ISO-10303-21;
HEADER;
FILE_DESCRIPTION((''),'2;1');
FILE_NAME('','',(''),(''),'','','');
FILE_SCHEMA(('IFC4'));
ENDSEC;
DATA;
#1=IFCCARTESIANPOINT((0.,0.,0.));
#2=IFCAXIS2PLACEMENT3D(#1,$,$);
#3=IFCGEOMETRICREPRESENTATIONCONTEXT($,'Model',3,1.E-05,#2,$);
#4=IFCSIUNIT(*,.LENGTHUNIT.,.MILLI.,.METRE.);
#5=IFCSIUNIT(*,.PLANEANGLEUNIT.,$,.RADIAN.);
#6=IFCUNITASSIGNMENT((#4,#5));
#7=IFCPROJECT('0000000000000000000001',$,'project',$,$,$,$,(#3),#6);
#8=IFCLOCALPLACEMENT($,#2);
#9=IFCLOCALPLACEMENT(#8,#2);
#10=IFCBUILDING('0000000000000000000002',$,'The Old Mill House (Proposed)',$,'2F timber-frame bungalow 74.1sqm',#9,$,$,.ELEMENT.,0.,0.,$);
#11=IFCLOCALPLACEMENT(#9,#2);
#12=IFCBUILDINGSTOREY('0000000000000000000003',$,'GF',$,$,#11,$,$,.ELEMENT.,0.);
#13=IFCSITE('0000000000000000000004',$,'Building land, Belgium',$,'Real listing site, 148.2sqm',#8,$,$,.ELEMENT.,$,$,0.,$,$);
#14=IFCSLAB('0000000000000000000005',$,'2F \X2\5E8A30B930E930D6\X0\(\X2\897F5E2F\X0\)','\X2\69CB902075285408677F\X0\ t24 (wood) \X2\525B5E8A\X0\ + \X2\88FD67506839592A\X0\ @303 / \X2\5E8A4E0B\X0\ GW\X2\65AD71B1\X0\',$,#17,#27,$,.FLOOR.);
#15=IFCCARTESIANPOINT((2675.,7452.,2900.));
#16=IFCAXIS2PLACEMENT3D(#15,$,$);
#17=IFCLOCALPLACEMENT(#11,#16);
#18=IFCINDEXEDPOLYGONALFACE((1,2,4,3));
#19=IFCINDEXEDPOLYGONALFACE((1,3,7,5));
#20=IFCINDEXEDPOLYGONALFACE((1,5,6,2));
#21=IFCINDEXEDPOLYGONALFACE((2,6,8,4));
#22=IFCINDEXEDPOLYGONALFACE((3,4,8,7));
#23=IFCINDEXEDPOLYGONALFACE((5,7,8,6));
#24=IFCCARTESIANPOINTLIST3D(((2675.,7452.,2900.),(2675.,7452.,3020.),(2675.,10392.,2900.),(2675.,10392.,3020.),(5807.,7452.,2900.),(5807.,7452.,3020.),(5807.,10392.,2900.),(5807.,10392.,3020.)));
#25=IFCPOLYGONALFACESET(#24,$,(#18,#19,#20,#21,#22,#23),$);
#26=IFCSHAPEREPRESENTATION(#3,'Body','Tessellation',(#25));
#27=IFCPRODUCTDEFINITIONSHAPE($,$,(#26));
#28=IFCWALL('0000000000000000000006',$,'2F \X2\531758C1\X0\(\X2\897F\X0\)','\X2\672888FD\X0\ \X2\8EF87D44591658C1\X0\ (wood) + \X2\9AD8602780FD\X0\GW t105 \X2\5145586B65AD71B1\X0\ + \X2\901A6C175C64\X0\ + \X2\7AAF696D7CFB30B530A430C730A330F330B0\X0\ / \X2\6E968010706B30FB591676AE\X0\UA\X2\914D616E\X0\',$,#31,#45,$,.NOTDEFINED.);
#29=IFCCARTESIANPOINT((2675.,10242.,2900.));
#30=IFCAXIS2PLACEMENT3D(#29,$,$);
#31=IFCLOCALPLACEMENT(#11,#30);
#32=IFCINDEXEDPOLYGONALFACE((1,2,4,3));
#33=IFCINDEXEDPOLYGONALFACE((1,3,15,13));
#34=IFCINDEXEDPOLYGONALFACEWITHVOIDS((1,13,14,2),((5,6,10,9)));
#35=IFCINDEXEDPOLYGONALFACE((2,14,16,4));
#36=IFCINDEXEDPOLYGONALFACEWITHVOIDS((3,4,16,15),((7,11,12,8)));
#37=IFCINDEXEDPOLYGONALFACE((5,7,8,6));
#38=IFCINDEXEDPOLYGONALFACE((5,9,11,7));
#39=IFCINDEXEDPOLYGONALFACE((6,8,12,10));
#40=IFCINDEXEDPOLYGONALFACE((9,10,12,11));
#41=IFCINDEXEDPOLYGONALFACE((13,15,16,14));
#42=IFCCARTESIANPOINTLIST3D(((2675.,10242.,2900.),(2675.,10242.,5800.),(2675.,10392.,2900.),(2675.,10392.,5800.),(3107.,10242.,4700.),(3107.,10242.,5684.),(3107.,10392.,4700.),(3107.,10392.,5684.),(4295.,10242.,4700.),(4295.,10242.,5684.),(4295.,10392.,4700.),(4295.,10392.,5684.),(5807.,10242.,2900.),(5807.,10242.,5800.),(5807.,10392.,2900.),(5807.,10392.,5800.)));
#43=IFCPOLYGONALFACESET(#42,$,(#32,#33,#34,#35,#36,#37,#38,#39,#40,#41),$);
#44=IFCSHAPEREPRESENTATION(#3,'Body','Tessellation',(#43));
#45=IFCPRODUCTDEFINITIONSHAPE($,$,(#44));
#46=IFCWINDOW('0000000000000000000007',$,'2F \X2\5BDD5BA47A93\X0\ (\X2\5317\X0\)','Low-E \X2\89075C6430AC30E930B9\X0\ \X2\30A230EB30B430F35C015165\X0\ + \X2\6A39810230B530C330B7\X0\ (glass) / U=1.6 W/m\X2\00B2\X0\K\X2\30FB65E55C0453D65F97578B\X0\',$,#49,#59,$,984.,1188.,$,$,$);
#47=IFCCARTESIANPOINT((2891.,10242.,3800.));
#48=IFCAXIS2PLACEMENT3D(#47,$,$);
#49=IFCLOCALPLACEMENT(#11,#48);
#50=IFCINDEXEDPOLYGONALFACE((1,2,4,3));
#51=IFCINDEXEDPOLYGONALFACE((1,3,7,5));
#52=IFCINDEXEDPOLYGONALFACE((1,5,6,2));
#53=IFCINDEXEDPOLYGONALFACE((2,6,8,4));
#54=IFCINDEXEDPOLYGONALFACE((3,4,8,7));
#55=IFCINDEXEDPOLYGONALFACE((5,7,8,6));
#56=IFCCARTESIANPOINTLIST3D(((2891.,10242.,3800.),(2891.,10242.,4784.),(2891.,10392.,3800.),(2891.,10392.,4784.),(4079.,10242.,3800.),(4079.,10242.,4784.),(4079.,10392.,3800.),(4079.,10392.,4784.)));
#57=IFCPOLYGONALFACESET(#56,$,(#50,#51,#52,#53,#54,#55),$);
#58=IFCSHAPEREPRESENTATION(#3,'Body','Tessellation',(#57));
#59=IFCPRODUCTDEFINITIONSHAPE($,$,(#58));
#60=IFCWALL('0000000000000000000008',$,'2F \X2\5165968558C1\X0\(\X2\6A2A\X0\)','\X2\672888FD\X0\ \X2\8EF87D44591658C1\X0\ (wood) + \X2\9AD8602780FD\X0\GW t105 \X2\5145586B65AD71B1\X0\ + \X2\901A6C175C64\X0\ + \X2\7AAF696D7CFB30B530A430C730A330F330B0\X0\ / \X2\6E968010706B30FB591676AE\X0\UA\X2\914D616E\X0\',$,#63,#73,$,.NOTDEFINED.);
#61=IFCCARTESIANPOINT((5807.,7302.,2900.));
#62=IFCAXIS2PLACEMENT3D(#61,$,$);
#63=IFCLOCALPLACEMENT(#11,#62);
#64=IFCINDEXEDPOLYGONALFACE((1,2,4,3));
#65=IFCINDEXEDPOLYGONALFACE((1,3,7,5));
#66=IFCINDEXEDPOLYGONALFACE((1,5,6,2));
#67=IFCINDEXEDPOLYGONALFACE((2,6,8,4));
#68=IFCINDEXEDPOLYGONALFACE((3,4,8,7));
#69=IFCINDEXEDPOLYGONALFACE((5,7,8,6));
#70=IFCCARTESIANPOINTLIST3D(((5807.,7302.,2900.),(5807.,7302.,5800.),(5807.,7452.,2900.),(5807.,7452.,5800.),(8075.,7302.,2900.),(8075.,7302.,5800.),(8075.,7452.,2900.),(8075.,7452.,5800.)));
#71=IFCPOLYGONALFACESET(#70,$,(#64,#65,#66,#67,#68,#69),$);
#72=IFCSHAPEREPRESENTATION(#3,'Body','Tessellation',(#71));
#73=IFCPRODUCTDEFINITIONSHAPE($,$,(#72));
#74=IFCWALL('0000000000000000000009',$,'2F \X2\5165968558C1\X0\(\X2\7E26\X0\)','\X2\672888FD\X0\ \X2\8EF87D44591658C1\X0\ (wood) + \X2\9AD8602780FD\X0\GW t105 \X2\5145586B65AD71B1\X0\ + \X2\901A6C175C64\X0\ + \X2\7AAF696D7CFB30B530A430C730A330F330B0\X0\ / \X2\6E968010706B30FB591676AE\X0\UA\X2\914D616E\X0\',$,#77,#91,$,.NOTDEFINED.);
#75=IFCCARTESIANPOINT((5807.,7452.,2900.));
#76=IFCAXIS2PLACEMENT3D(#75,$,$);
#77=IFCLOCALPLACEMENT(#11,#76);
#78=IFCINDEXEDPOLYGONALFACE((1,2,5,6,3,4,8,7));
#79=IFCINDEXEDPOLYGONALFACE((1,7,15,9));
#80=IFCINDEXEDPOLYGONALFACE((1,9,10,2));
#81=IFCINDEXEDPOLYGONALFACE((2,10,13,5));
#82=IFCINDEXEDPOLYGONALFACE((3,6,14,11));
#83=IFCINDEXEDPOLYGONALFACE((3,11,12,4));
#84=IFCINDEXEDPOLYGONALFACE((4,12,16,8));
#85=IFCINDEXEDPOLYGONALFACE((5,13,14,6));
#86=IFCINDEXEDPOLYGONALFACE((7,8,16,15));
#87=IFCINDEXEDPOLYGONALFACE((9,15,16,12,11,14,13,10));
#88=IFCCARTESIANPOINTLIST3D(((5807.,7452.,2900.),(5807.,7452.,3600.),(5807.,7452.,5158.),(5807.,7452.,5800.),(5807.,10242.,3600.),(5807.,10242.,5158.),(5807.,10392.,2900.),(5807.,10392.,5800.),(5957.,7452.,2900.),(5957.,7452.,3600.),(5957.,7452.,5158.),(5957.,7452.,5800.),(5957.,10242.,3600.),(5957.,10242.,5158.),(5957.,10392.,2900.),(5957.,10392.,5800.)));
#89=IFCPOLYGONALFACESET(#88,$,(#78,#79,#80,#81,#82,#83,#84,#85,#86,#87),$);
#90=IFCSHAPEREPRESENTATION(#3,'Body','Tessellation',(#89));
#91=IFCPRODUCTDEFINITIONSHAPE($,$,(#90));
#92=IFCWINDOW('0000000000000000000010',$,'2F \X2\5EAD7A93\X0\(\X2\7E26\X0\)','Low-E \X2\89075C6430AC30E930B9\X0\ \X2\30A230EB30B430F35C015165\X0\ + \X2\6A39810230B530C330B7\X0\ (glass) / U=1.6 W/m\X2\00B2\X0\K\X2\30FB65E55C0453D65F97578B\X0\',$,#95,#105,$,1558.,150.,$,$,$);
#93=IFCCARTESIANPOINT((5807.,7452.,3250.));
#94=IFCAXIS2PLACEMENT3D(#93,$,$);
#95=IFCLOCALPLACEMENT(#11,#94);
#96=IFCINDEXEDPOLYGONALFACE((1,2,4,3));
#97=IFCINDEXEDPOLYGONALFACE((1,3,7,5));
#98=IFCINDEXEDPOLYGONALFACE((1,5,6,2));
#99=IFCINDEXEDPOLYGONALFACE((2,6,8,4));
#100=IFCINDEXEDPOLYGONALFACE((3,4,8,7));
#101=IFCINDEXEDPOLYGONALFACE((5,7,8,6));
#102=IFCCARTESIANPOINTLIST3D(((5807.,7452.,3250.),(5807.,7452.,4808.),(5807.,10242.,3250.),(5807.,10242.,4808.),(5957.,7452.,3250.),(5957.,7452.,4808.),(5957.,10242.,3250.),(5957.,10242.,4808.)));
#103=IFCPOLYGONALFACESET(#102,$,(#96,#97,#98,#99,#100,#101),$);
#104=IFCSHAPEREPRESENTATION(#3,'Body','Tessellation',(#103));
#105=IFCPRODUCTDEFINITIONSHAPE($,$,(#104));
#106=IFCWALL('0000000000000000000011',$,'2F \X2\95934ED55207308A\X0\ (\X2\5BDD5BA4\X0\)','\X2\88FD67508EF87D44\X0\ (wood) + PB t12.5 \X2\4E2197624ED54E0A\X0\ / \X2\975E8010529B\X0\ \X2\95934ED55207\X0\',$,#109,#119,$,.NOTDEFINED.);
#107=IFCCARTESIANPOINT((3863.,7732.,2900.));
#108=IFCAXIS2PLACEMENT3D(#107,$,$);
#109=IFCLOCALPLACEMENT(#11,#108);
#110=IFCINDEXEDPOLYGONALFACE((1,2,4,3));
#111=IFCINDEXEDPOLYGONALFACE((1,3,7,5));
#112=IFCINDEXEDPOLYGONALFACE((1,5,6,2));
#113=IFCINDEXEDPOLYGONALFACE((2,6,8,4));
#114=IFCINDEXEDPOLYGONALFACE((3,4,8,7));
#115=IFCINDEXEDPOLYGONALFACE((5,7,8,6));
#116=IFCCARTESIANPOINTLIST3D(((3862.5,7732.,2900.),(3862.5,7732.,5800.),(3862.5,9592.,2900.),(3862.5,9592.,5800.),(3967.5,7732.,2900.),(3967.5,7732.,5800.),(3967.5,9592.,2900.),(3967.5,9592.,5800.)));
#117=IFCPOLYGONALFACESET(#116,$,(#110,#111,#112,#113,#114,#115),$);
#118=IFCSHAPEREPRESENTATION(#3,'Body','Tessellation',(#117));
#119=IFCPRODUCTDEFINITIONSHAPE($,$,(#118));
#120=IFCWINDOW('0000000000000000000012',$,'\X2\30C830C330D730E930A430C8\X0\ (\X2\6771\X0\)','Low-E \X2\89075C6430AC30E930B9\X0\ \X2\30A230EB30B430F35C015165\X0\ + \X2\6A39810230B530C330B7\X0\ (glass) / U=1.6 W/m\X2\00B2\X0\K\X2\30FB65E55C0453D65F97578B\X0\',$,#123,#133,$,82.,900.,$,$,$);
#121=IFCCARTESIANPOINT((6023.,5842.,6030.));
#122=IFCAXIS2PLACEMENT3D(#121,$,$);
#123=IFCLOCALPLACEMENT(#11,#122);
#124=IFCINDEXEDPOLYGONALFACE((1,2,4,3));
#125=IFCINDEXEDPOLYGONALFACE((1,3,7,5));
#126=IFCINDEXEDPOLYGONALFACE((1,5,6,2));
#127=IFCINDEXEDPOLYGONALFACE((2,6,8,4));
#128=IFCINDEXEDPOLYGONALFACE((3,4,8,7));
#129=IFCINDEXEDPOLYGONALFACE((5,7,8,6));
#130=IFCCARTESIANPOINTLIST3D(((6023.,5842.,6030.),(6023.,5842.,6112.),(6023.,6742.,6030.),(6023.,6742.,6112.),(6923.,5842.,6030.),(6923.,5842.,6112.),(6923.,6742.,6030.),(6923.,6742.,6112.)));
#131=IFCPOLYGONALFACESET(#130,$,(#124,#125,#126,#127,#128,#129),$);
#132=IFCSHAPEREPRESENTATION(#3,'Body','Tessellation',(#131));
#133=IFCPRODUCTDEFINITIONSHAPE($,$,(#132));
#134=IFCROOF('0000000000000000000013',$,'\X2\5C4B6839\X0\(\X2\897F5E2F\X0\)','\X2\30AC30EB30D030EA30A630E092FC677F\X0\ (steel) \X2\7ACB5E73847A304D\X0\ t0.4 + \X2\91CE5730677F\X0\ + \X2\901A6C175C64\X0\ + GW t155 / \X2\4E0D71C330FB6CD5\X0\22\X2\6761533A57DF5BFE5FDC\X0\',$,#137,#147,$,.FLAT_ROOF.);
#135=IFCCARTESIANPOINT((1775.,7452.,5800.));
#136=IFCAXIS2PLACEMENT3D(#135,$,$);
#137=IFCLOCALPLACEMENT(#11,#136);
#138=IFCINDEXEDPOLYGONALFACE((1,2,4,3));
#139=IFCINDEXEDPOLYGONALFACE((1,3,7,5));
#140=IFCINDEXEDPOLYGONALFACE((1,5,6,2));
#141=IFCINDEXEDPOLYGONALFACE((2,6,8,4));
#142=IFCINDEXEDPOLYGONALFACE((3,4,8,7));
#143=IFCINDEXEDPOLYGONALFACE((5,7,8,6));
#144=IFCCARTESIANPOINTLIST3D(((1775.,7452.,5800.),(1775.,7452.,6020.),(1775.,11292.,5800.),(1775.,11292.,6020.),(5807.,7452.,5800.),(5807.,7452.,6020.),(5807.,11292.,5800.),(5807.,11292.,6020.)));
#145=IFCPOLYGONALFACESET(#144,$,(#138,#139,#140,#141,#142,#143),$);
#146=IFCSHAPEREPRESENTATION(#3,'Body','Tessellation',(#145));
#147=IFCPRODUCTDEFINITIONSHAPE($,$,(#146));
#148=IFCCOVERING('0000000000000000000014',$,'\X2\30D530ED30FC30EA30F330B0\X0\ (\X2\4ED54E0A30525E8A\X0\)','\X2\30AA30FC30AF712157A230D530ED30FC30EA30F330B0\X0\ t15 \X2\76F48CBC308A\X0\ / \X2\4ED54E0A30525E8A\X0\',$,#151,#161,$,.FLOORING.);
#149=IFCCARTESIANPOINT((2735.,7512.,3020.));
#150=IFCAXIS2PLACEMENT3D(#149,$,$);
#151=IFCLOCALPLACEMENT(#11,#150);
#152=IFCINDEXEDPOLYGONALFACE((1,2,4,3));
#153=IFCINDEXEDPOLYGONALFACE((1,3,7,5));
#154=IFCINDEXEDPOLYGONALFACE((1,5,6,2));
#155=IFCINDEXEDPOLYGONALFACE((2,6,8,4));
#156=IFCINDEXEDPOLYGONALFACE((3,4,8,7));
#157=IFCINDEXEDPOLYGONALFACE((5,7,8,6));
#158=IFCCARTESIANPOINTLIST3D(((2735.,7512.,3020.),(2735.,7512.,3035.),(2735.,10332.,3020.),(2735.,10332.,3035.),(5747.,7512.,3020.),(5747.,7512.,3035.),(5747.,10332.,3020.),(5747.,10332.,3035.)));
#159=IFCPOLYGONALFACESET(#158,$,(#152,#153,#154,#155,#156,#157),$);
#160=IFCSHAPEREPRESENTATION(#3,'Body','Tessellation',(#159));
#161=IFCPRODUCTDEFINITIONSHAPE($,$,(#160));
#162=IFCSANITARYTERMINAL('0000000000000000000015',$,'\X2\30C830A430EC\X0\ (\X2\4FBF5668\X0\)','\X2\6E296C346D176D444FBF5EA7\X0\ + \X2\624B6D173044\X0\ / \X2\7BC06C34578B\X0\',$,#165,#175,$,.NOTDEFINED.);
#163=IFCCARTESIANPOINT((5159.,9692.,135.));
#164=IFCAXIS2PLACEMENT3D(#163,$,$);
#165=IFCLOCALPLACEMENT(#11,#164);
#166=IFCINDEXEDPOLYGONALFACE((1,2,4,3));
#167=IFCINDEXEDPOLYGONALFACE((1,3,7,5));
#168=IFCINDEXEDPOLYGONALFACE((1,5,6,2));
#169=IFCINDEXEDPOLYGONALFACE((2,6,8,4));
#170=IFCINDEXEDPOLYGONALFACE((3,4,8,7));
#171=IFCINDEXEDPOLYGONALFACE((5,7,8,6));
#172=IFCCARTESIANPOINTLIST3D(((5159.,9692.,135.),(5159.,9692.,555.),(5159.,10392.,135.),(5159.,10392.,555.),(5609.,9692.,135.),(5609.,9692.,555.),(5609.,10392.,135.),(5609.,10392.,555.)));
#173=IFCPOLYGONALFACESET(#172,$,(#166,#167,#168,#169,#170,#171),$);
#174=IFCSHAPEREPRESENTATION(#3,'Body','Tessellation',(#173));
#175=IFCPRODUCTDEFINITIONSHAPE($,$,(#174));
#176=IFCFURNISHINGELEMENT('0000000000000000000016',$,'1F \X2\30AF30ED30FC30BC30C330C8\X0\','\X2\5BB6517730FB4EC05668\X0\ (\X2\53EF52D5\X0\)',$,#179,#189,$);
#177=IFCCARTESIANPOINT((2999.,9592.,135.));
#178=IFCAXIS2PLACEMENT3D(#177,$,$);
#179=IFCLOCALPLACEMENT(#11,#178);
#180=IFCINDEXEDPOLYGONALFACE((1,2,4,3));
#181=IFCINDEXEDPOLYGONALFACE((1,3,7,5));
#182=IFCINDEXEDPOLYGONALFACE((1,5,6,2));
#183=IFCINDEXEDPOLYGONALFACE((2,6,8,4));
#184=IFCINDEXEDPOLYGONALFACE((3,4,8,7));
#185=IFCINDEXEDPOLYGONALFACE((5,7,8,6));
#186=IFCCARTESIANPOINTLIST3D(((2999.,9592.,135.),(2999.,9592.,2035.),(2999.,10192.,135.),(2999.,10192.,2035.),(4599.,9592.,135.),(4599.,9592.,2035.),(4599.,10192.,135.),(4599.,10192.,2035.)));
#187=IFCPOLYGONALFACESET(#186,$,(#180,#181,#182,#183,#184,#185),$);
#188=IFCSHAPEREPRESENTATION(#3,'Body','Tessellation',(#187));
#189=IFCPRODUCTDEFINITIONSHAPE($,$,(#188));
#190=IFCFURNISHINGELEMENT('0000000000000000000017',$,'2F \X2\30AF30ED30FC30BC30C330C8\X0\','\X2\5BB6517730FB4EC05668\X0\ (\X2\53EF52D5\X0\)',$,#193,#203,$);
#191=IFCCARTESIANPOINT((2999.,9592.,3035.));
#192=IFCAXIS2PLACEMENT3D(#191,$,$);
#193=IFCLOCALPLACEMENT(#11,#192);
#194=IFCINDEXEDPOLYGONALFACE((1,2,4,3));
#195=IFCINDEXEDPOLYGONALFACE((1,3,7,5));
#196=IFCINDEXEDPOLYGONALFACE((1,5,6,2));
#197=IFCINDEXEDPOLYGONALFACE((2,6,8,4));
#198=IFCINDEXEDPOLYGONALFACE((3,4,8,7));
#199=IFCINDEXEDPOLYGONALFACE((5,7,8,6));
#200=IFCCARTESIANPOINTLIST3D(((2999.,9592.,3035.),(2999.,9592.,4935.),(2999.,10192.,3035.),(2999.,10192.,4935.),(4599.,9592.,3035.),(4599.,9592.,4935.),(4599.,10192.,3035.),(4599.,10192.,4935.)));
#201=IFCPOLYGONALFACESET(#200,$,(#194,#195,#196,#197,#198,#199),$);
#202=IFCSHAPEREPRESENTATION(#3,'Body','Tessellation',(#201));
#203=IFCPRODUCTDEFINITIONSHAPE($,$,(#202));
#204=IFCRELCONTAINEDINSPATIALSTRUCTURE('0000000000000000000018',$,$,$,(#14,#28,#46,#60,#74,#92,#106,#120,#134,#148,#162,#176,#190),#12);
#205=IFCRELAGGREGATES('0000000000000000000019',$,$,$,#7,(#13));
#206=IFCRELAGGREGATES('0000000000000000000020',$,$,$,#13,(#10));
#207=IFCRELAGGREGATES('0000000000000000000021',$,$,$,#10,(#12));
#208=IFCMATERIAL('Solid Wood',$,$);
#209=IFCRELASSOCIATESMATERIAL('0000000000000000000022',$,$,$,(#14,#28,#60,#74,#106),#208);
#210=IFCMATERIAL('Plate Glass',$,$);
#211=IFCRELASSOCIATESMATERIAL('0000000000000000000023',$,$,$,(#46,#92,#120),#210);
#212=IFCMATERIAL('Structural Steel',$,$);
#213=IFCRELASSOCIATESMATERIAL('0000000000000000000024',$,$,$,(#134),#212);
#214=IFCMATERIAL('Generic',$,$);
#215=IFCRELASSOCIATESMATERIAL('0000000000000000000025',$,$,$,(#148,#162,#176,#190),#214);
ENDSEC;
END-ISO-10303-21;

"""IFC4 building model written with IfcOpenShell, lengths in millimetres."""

from ifc_helpers import new_model, si_unit, frame, frame_2d, origin, place, context, project, spatial, rectangle, extrude, material, element, fill, save


model = new_model("IFC4")

# Units and contexts
model_context = context("Model", 3, precision=1e-05, world=origin())
ifc_project = project(units=[si_unit("LENGTHUNIT", "METRE", prefix="MILLI"), si_unit("PLANEANGLEUNIT", "RADIAN")], contexts=[model_context])

# Site, building, storey
site_placement = place(None, origin())
site = spatial("IfcSite", under=ifc_project, at=site_placement, Name="Building land, Belgium", ObjectType="Real listing site, 148.2sqm", CompositionType="ELEMENT", RefElevation=0.0)
building_placement = place(site_placement, origin())
building = spatial("IfcBuilding", under=site, at=building_placement, Name="The Old Mill House (Proposed)", ObjectType="2F timber-frame bungalow 74.1sqm", CompositionType="ELEMENT", ElevationOfRefHeight=0.0, ElevationOfTerrain=0.0)
storey_placement = place(building_placement, origin())
storey = spatial("IfcBuildingStorey", under=building, at=storey_placement, Name="GF", CompositionType="ELEMENT", Elevation=0.0)

# Slab
ifc_material_1 = material(Name="Solid Wood")
slab_placement = place(storey_placement, frame((2675.0, 7452.0, 2900.0)))
element("IfcSlab", 1, at=slab_placement, inside=storey, material=ifc_material_1, Name="2F 床スラブ(西帯)", Description="構造用合板 t24 (wood) 剛床 + 製材根太 @303 / 床下 GW断熱", PredefinedType="FLOOR", context=model_context, shape_type="SweptSolid", body=[
    extrude(rectangle(XDim=3132.0, YDim=2940.0, at=frame_2d((1566.0, 1470.0))), frame((2675.0, 7452.0, 2900.0)), (0.0, 0.0, 1.0), 120.0),
])

# Wall, opening, window
wall_1_placement = place(storey_placement, frame((2675.0, 10242.0, 2900.0)))
wall_1 = element("IfcWall", 2, at=wall_1_placement, inside=storey, material=ifc_material_1, Name="2F 北壁(西)", Description="木製 軸組外壁 (wood) + 高性能GW t105 充填断熱 + 通気層 + 窯業系サイディング / 準耐火・外皮UA配慮", PredefinedType="NOTDEFINED", context=model_context, shape_type="SweptSolid", body=[
    extrude(rectangle(XDim=3132.0, YDim=150.0, at=frame_2d((1566.0, 75.0))), frame((2675.0, 10242.0, 2900.0)), (0.0, 0.0, 1.0), 2900.0),
])
opening_1_placement = place(storey_placement, frame((2891.0, 10242.0, 3800.0)))
opening_1 = element("IfcOpeningElement", 3, at=opening_1_placement, cuts=wall_1, PredefinedType="NOTDEFINED", context=model_context, shape_type="SweptSolid", body=[
    extrude(rectangle(XDim=1188.0, YDim=150.0, at=frame_2d((594.0, 75.0))), frame((2891.0, 10242.0, 3800.0)), (0.0, 0.0, 1.0), 984.0),
])
ifc_material_2 = material(Name="Plate Glass")
window_1_placement = place(storey_placement, frame((2891.0, 10242.0, 3800.0)))
window_1 = element("IfcWindow", 4, at=window_1_placement, inside=storey, material=ifc_material_2, Name="2F 寝室窓 (北)", Description="Low-E 複層ガラス アルゴン封入 + 樹脂サッシ (glass) / U=1.6 W/m²K・日射取得型", OverallHeight=984.0, OverallWidth=1188.0, context=model_context, shape_type="SweptSolid", body=[
    extrude(rectangle(XDim=1188.0, YDim=150.0, at=frame_2d((594.0, 75.0))), frame((2891.0, 10242.0, 3800.0)), (0.0, 0.0, 1.0), 984.0),
])
fill(opening_1, window_1)

# Wall
wall_2_placement = place(storey_placement, frame((5807.0, 7302.0, 2900.0)))
element("IfcWall", 5, at=wall_2_placement, inside=storey, material=ifc_material_1, Name="2F 入隅壁(横)", Description="木製 軸組外壁 (wood) + 高性能GW t105 充填断熱 + 通気層 + 窯業系サイディング / 準耐火・外皮UA配慮", PredefinedType="NOTDEFINED", context=model_context, shape_type="SweptSolid", body=[
    extrude(rectangle(XDim=2268.0, YDim=150.0, at=frame_2d((1134.0, 75.0))), frame((5807.0, 7302.0, 2900.0)), (0.0, 0.0, 1.0), 2900.0),
])

# Wall, opening, window
wall_3_placement = place(storey_placement, frame((5807.0, 7452.0, 2900.0)))
wall_3 = element("IfcWall", 6, at=wall_3_placement, inside=storey, material=ifc_material_1, Name="2F 入隅壁(縦)", Description="木製 軸組外壁 (wood) + 高性能GW t105 充填断熱 + 通気層 + 窯業系サイディング / 準耐火・外皮UA配慮", PredefinedType="NOTDEFINED", context=model_context, shape_type="SweptSolid", body=[
    extrude(rectangle(XDim=150.0, YDim=2940.0, at=frame_2d((75.0, 1470.0))), frame((5807.0, 7452.0, 2900.0)), (0.0, 0.0, 1.0), 2900.0),
])
opening_2_placement = place(storey_placement, frame((5807.0, 7452.0, 3250.0)))
opening_2 = element("IfcOpeningElement", 7, at=opening_2_placement, cuts=wall_3, PredefinedType="NOTDEFINED", context=model_context, shape_type="SweptSolid", body=[
    extrude(rectangle(XDim=150.0, YDim=2790.0, at=frame_2d((75.0, 1395.0))), frame((5807.0, 7452.0, 3250.0)), (0.0, 0.0, 1.0), 1558.0),
])
window_2_placement = place(storey_placement, frame((5807.0, 7452.0, 3250.0)))
window_2 = element("IfcWindow", 8, at=window_2_placement, inside=storey, material=ifc_material_2, Name="2F 庭窓(縦)", Description="Low-E 複層ガラス アルゴン封入 + 樹脂サッシ (glass) / U=1.6 W/m²K・日射取得型", OverallHeight=1558.0, OverallWidth=150.0, context=model_context, shape_type="SweptSolid", body=[
    extrude(rectangle(XDim=150.0, YDim=2790.0, at=frame_2d((75.0, 1395.0))), frame((5807.0, 7452.0, 3250.0)), (0.0, 0.0, 1.0), 1558.0),
])
fill(opening_2, window_2)

# Wall
wall_4_placement = place(storey_placement, frame((3863.0, 7732.0, 2900.0)))
element("IfcWall", 9, at=wall_4_placement, inside=storey, material=ifc_material_1, Name="2F 間仕切り (寝室)", Description="製材軸組 (wood) + PB t12.5 両面仕上 / 非耐力 間仕切", PredefinedType="NOTDEFINED", context=model_context, shape_type="SweptSolid", body=[
    extrude(rectangle(XDim=105.0, YDim=1860.0, at=frame_2d((52.0, 930.0))), frame((3863.0, 7732.0, 2900.0)), (0.0, 0.0, 1.0), 2900.0),
])

# Window
window_3_placement = place(storey_placement, frame((6023.0, 5842.0, 6030.0)))
element("IfcWindow", 10, at=window_3_placement, inside=storey, material=ifc_material_2, Name="トップライト (東)", Description="Low-E 複層ガラス アルゴン封入 + 樹脂サッシ (glass) / U=1.6 W/m²K・日射取得型", OverallHeight=82.0, OverallWidth=900.0, context=model_context, shape_type="SweptSolid", body=[
    extrude(rectangle(XDim=900.0, YDim=900.0, at=frame_2d((450.0, 450.0))), frame((6023.0, 5842.0, 6030.0)), (0.0, 0.0, 1.0), 82.0),
])

# Roof
ifc_material_3 = material(Name="Structural Steel")
for number, where, name in (
    (11, (1775.0, 7452.0, 5800.0), "屋根(西帯)"),
):
    element("IfcRoof", number, at=place(storey_placement, frame(where)), inside=storey, material=ifc_material_3, Name=name, Description="ガルバリウム鋼板 (steel) 立平葺き t0.4 + 野地板 + 通気層 + GW t155 / 不燃・法22条区域対応", PredefinedType="FLAT_ROOF", context=model_context, shape_type="SweptSolid", body=[
        extrude(rectangle(XDim=4032.0, YDim=3840.0, at=frame_2d((2016.0, 1920.0))), frame((1775.0, 7452.0, 5800.0)), (0.0, 0.0, 1.0), 220.0),
    ])

# Covering
ifc_material_4 = material(Name="Generic")
covering_placement = place(storey_placement, frame((2735.0, 7512.0, 3020.0)))
element("IfcCovering", 12, at=covering_placement, inside=storey, material=ifc_material_4, Name="フローリング (仕上げ床)", Description="オーク無垢フローリング t15 直貼り / 仕上げ床", PredefinedType="FLOORING", context=model_context, shape_type="SweptSolid", body=[
    extrude(rectangle(XDim=3012.0, YDim=2820.0, at=frame_2d((1506.0, 1410.0))), frame((2735.0, 7512.0, 3020.0)), (0.0, 0.0, 1.0), 15.0),
])

# Sanitary terminal
sanitary_terminal_placement = place(storey_placement, frame((5159.0, 9692.0, 135.0)))
element("IfcSanitaryTerminal", 13, at=sanitary_terminal_placement, inside=storey, material=ifc_material_4, Name="トイレ (便器)", Description="温水洗浄便座 + 手洗い / 節水型", PredefinedType="NOTDEFINED", context=model_context, shape_type="SweptSolid", body=[
    extrude(rectangle(XDim=450.0, YDim=700.0, at=frame_2d((225.0, 350.0))), frame((5159.0, 9692.0, 135.0)), (0.0, 0.0, 1.0), 420.0),
])

# Furnishing elements
furnishing_1_placement = place(storey_placement, frame((2999.0, 9592.0, 135.0)))
element("IfcFurnishingElement", 14, at=furnishing_1_placement, inside=storey, material=ifc_material_4, Name="1F クローゼット", Description="家具・什器 (可動)", context=model_context, shape_type="SweptSolid", body=[
    extrude(rectangle(XDim=1600.0, YDim=600.0, at=frame_2d((800.0, 300.0))), frame((2999.0, 9592.0, 135.0)), (0.0, 0.0, 1.0), 1900.0),
])
furnishing_2_placement = place(storey_placement, frame((2999.0, 9592.0, 3035.0)))
element("IfcFurnishingElement", 15, at=furnishing_2_placement, inside=storey, material=ifc_material_4, Name="2F クローゼット", Description="家具・什器 (可動)", context=model_context, shape_type="SweptSolid", body=[
    extrude(rectangle(XDim=1600.0, YDim=600.0, at=frame_2d((800.0, 300.0))), frame((2999.0, 9592.0, 3035.0)), (0.0, 0.0, 1.0), 1900.0),
])

save(model, "model.ifc")
